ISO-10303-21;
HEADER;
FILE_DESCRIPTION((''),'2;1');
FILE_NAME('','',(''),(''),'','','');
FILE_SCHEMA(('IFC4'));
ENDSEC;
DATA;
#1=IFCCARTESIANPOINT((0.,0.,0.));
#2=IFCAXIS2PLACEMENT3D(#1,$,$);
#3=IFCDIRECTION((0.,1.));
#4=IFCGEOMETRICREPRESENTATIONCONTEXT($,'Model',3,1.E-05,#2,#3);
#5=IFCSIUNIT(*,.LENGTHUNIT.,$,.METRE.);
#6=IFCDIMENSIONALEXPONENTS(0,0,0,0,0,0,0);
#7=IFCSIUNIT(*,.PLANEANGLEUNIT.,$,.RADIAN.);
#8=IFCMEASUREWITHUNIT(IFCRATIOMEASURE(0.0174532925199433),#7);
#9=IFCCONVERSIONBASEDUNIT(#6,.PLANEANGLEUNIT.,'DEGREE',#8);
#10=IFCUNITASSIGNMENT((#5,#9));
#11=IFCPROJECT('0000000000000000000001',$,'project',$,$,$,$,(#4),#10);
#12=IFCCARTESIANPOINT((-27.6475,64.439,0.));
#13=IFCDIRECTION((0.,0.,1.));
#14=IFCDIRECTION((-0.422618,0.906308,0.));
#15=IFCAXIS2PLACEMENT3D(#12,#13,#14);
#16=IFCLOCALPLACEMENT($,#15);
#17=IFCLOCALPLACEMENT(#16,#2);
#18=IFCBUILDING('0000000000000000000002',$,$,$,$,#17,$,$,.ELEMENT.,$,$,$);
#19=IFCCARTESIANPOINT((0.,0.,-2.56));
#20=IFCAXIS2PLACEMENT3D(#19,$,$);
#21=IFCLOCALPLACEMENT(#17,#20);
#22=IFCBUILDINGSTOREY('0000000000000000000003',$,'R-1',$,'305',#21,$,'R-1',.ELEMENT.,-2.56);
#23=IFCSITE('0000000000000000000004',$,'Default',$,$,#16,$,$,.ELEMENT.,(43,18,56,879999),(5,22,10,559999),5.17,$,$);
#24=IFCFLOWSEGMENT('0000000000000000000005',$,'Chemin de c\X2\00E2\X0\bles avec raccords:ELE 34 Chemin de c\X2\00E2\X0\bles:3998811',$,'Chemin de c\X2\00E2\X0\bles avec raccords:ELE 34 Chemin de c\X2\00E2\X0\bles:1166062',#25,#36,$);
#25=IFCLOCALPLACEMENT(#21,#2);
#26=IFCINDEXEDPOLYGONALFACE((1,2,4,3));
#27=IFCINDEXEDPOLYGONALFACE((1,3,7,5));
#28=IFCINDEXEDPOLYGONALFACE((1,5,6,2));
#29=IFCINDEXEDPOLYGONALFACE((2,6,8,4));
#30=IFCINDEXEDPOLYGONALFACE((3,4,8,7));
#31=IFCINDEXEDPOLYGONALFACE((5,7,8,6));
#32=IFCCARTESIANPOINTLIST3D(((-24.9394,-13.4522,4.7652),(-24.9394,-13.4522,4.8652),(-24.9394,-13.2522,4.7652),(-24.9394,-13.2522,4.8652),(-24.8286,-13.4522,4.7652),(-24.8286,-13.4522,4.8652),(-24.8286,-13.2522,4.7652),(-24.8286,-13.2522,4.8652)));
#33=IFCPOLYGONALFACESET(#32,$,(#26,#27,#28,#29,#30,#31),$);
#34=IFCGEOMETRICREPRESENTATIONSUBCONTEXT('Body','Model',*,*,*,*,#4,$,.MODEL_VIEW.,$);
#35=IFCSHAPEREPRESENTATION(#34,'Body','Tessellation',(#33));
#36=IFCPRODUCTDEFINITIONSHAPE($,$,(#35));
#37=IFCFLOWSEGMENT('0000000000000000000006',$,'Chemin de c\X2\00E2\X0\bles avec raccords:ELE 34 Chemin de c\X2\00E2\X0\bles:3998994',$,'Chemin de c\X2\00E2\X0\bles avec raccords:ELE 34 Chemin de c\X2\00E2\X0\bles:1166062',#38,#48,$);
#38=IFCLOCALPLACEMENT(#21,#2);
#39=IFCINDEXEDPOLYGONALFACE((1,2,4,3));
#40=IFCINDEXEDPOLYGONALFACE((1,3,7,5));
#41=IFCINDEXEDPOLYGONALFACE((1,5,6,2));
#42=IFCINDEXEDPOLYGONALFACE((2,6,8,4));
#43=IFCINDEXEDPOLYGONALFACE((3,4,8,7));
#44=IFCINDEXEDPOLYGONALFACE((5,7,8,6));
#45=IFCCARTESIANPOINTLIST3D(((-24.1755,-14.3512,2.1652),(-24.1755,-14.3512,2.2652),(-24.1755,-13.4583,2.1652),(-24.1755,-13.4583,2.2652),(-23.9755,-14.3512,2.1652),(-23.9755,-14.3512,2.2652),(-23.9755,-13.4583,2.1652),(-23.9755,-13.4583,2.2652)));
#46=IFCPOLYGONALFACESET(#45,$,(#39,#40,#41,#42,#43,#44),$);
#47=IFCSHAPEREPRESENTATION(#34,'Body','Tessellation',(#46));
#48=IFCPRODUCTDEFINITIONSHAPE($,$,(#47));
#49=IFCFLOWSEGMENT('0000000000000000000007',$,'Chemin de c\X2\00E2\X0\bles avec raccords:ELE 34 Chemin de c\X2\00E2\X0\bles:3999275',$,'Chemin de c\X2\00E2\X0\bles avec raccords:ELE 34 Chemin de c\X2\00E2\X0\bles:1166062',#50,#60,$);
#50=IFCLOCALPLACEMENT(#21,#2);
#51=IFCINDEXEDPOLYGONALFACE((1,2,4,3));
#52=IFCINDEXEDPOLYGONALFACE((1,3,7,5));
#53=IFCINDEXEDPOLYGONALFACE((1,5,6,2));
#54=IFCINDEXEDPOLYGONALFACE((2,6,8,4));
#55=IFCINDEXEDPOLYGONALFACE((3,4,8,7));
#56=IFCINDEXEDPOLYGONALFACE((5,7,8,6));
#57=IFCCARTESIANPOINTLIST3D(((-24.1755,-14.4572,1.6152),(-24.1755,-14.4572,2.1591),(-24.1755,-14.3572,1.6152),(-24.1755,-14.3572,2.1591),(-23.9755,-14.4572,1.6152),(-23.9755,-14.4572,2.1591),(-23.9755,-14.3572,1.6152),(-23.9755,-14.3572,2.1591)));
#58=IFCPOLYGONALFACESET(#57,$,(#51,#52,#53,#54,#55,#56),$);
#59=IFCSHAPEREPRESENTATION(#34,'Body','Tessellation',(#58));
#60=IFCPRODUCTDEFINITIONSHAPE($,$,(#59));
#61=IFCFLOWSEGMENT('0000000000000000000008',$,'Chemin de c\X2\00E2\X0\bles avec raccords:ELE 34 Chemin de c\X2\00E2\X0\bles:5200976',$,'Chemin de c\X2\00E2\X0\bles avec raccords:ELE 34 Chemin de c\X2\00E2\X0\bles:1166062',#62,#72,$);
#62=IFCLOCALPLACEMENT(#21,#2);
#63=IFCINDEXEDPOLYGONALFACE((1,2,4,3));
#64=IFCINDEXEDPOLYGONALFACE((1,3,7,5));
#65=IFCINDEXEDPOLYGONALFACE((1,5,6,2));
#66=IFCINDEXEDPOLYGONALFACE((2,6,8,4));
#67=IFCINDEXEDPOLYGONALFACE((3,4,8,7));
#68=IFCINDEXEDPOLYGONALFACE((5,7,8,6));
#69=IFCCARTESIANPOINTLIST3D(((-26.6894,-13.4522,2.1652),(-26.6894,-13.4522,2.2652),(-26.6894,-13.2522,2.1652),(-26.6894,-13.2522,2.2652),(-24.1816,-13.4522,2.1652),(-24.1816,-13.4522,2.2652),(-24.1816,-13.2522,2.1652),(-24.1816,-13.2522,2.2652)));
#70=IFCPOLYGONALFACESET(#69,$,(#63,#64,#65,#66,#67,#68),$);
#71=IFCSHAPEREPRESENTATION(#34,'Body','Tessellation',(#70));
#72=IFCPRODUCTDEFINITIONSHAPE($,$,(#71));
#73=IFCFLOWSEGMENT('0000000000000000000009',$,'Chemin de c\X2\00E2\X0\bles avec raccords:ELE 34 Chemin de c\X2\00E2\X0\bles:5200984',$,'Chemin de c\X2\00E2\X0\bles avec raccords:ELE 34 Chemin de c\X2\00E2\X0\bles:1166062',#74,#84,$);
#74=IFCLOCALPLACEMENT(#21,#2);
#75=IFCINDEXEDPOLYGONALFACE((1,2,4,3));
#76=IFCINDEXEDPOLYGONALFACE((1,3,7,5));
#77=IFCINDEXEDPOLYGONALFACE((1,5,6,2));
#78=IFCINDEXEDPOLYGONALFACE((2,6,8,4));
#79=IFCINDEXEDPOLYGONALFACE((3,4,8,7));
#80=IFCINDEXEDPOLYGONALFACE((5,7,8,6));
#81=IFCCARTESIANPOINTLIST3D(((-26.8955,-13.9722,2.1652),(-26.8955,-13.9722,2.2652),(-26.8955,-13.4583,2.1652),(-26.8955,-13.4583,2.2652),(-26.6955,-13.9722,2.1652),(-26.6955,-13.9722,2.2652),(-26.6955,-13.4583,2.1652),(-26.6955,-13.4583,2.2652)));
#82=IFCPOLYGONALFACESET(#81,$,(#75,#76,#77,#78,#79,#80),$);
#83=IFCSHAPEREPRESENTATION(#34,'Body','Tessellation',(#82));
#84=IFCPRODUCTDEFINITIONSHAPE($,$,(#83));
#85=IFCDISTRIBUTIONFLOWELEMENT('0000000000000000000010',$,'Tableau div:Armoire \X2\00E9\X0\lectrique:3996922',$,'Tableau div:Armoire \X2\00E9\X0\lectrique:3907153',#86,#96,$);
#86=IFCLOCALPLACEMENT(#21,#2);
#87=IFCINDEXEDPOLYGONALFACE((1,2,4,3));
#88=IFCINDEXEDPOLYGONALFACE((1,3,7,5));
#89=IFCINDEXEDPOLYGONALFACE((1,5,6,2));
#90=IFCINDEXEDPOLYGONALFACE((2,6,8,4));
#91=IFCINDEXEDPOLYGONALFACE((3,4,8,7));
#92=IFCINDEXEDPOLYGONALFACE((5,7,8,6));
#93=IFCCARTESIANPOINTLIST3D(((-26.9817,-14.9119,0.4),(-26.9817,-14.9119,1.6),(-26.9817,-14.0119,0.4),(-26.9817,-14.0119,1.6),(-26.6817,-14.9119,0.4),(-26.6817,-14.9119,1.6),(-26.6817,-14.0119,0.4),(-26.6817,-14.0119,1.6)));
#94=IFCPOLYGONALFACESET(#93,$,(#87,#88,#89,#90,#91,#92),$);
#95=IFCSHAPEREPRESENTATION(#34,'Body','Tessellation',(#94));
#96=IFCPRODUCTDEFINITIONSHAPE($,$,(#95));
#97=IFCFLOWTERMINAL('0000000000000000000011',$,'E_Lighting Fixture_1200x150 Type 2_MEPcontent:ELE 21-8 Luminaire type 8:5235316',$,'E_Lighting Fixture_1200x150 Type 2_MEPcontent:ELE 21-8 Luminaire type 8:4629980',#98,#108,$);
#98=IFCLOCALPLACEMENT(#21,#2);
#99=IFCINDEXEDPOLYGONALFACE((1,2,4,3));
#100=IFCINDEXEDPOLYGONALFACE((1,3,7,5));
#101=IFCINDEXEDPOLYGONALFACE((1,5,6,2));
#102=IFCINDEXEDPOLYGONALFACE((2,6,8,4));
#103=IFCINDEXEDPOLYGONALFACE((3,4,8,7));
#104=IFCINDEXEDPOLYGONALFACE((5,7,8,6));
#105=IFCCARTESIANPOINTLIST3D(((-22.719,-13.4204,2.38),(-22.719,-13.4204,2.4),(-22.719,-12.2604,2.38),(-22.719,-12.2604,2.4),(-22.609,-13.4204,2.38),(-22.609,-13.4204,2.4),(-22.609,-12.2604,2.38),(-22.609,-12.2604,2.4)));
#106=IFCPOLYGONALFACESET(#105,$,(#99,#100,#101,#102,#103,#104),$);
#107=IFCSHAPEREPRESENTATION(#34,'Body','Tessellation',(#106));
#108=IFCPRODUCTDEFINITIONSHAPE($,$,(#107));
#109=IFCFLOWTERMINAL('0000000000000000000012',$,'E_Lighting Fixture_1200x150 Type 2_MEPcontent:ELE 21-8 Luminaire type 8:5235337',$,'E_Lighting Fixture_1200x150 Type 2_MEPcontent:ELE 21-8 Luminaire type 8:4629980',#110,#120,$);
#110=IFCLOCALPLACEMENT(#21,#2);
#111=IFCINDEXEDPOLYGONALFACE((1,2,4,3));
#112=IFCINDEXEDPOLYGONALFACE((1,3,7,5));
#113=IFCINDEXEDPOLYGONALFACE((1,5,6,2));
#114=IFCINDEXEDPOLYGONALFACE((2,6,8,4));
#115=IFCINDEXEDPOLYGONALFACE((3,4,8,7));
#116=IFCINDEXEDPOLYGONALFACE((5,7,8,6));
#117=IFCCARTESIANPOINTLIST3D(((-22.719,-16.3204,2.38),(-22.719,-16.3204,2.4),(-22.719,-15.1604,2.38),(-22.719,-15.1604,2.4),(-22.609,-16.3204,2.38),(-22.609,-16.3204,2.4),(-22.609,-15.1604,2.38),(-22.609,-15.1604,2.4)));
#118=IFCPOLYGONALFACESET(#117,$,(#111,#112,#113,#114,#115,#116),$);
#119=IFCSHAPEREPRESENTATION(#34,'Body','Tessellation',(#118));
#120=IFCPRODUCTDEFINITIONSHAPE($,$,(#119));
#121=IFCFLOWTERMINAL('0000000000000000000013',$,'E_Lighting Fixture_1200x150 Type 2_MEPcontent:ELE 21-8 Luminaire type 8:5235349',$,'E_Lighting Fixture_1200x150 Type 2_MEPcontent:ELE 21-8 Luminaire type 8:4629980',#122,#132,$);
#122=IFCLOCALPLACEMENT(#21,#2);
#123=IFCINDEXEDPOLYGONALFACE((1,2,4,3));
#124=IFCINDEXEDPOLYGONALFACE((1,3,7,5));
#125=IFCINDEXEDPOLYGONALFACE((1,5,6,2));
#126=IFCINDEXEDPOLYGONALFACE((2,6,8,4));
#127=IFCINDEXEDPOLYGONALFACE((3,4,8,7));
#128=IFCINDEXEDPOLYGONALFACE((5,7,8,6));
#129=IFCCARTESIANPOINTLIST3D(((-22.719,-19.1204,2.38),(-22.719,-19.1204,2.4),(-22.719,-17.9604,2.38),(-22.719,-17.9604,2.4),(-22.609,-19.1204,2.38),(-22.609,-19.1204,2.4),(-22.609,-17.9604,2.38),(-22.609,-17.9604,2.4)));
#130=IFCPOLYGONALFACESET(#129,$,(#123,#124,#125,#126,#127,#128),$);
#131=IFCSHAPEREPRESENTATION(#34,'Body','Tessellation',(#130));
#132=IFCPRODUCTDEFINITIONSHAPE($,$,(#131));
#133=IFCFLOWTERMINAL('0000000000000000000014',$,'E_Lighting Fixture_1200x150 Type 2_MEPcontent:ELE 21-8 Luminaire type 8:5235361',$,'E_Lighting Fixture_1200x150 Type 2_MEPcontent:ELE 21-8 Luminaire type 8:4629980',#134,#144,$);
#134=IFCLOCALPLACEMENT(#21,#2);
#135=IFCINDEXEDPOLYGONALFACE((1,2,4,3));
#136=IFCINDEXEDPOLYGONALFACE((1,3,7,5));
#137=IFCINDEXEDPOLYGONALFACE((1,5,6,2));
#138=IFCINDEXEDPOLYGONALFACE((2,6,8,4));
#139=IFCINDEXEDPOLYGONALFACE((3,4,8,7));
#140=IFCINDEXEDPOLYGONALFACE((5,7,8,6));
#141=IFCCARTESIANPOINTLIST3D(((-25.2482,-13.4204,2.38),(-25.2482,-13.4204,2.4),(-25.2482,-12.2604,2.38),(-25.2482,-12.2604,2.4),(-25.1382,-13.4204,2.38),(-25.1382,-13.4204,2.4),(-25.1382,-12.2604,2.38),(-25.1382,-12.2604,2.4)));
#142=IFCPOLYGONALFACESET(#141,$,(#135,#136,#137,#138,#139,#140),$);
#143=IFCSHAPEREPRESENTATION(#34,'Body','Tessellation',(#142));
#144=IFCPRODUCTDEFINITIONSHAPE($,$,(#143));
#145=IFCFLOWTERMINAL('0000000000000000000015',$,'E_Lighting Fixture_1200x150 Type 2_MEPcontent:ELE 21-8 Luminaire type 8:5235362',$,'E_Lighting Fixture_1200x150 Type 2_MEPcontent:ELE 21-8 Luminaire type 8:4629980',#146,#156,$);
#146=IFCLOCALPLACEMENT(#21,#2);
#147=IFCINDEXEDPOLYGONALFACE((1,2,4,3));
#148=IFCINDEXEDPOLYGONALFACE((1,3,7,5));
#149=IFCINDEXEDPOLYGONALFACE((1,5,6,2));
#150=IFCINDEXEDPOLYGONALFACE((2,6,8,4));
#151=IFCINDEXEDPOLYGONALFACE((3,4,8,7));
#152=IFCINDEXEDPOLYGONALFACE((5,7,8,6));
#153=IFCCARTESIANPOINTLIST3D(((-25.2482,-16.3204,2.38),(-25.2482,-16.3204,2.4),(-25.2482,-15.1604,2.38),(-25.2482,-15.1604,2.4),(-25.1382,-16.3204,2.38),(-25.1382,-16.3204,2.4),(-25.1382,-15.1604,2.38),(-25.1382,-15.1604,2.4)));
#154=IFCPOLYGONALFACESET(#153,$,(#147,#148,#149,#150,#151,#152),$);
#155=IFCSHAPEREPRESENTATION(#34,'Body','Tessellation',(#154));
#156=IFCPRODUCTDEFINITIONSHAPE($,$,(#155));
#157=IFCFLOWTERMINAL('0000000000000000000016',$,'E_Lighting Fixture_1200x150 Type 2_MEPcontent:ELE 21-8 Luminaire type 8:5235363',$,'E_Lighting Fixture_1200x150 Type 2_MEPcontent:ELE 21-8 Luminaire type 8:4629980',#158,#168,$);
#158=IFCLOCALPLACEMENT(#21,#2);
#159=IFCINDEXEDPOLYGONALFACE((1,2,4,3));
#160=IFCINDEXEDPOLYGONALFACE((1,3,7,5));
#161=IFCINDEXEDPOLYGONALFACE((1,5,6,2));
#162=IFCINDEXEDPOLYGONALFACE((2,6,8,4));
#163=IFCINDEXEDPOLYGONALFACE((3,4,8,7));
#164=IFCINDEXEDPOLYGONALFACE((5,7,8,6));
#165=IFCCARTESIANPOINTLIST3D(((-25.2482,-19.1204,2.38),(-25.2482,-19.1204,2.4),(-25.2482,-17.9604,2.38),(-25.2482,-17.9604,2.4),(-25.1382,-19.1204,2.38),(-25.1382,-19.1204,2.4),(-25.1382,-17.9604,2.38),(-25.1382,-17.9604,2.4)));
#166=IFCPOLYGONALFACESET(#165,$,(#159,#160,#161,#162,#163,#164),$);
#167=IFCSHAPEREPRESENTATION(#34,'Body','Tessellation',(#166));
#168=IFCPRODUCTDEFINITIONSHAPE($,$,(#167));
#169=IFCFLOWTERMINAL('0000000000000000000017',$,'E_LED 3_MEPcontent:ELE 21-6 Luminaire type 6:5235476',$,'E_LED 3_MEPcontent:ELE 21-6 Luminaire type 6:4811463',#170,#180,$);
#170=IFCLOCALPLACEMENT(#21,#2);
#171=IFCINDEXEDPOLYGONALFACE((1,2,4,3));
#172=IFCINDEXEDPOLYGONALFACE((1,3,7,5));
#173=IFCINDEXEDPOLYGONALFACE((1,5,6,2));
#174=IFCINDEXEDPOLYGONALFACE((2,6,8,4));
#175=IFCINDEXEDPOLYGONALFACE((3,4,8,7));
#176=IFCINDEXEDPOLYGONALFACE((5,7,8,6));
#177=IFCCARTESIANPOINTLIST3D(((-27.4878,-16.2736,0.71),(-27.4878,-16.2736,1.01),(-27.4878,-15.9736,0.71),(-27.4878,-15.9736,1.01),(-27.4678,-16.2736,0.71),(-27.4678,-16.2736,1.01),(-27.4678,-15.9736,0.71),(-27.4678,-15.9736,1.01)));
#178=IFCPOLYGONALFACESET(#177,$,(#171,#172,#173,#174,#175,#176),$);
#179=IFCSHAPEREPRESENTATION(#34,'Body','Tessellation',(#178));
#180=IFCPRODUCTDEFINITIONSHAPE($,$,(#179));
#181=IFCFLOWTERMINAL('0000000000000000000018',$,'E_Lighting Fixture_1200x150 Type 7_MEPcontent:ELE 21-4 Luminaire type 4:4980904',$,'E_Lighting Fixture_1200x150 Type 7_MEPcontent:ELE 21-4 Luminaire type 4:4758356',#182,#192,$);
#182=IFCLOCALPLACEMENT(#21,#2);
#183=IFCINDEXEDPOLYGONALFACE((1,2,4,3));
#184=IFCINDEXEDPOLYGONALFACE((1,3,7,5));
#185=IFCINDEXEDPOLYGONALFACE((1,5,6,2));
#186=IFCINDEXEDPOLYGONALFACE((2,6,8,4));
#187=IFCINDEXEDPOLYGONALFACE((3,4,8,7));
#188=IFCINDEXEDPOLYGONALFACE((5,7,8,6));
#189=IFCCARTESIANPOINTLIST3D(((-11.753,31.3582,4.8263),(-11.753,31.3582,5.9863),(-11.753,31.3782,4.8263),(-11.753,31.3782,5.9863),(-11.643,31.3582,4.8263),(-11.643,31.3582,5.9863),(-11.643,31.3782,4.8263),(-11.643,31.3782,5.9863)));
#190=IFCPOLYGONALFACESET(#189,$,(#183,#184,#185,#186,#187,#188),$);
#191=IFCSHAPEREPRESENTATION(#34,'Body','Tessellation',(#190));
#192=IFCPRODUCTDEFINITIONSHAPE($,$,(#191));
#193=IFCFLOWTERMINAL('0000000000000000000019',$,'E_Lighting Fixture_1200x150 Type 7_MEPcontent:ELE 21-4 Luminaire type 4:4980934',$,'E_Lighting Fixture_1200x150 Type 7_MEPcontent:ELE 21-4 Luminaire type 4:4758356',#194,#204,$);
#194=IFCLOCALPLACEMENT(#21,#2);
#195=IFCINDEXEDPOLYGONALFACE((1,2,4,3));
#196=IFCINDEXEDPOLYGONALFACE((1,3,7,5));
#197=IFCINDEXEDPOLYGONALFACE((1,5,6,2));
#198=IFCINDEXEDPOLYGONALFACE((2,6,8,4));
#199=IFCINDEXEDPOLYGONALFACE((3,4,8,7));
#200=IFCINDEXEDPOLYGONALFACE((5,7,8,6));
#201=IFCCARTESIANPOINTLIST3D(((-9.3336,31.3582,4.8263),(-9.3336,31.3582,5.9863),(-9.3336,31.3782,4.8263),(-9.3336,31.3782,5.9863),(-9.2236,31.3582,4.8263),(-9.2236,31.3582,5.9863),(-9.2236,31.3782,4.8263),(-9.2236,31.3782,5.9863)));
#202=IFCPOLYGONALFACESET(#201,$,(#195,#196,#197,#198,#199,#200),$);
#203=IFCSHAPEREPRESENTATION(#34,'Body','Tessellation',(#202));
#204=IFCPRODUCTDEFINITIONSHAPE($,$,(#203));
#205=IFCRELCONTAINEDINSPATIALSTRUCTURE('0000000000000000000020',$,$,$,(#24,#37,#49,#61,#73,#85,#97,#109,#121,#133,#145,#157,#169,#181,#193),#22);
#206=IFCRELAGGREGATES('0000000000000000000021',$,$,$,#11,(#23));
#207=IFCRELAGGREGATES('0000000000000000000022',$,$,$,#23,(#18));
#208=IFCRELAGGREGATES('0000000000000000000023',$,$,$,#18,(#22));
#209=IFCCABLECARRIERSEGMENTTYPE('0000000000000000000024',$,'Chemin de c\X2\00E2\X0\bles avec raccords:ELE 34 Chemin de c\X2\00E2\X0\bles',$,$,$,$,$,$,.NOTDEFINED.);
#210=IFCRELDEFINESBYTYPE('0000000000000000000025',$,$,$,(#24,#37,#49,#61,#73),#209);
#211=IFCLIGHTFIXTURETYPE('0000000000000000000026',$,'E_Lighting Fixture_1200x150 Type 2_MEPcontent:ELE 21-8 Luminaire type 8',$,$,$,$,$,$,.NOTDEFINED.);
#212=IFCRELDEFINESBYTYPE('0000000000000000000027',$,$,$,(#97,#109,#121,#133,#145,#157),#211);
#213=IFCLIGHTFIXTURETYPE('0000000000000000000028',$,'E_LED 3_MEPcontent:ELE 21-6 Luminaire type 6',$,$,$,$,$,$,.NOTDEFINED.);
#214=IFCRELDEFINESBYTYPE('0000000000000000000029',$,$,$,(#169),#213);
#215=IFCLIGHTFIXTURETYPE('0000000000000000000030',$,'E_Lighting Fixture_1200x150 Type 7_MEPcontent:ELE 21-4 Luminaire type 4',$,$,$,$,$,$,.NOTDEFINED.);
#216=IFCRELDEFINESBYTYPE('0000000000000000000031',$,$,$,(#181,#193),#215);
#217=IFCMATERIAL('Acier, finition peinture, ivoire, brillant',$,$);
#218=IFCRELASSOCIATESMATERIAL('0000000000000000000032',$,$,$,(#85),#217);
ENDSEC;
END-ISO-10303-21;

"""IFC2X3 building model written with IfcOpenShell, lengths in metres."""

from ifc_helpers import new_model, entity, si_unit, converted_unit, direction, frame, frame_2d, origin, origin_2d_with_axis, place, context, subcontext, project, spatial, rectangle, extrude, source, transform, mapped, material, type_object, type_shapes, element, save


model = new_model("IFC2X3")

# Units and contexts
model_context = context("Model", 3, precision=1e-05, world=origin(), true_north=direction((0.0, 1.0)))
body_context = subcontext(model_context, "Body", "Model", "MODEL_VIEW")
ifc_project = project(units=[si_unit("LENGTHUNIT", "METRE"), converted_unit("PLANEANGLEUNIT", "DEGREE", entity("IfcRatioMeasure", 0.0174532925199433), si_unit("PLANEANGLEUNIT", "RADIAN"), dimensions=[0, 0, 0, 0, 0, 0, 0])], contexts=[model_context])

# Site, building, storey
site_placement = place(None, frame((-27.6475, 64.439, 0.0), z_axis=(0.0, 0.0, 1.0), x_axis=(-0.422618, 0.906308, 0.0)))
site = spatial("IfcSite", under=ifc_project, at=site_placement, Name="Default", CompositionType="ELEMENT", RefLatitude=(43, 18, 56, 879999), RefLongitude=(5, 22, 10, 559999), RefElevation=5.17)
building_placement = place(site_placement, origin())
building = spatial("IfcBuilding", under=site, at=building_placement, CompositionType="ELEMENT")
storey_placement = place(building_placement, frame((0.0, 0.0, -2.56)))
storey = spatial("IfcBuildingStorey", under=building, at=storey_placement, Name="R-1", ObjectType="305", LongName="R-1", CompositionType="ELEMENT", Elevation=-2.56)

# Flow segments
cable_carrier_segment_type = type_object("IfcCableCarrierSegmentType", Name="Chemin de câbles avec raccords:ELE 34 Chemin de câbles", PredefinedType="NOTDEFINED")
flow_segment_1_placement = place(storey_placement, origin())
element("IfcFlowSegment", 1, at=flow_segment_1_placement, inside=storey, type_object=cable_carrier_segment_type, Name="Chemin de câbles avec raccords:ELE 34 Chemin de câbles:3998811", ObjectType="Chemin de câbles avec raccords:ELE 34 Chemin de câbles:1166062", context=body_context, shape_type="SweptSolid", body=[
    extrude(rectangle(XDim=0.1109, YDim=0.2, at=frame_2d((0.0, 0.0), x_axis=(1.0, 0.0))), frame((-24.884, -13.3522, 4.7652)), (0.0, 0.0, 1.0), 0.1),
])
flow_segment_2_placement = place(storey_placement, origin())
element("IfcFlowSegment", 2, at=flow_segment_2_placement, inside=storey, type_object=cable_carrier_segment_type, Name="Chemin de câbles avec raccords:ELE 34 Chemin de câbles:3998994", ObjectType="Chemin de câbles avec raccords:ELE 34 Chemin de câbles:1166062", context=body_context, shape_type="SweptSolid", body=[
    extrude(rectangle(XDim=0.8928, YDim=0.2, at=frame_2d((0.0, 0.0), x_axis=(1.0, 0.0))), frame((-24.0755, -13.9047, 2.1652), z_axis=(0.0, -0.000001, 1.0), x_axis=(0.0, -1.0, -0.000001)), (0.0, 0.0, 1.0), 0.1),
])
flow_segment_3_placement = place(storey_placement, origin())
element("IfcFlowSegment", 3, at=flow_segment_3_placement, inside=storey, type_object=cable_carrier_segment_type, Name="Chemin de câbles avec raccords:ELE 34 Chemin de câbles:3999275", ObjectType="Chemin de câbles avec raccords:ELE 34 Chemin de câbles:1166062", context=body_context, shape_type="SweptSolid", body=[
    extrude(rectangle(XDim=0.1, YDim=0.2, at=origin_2d_with_axis()), frame((-24.0755, -14.4072, 1.6152), z_axis=(0.0, 0.0, 1.0), x_axis=(0.0, -1.0, 0.0)), (0.0, 0.0, 1.0), 0.5439),
])
flow_segment_4_placement = place(storey_placement, origin())
element("IfcFlowSegment", 4, at=flow_segment_4_placement, inside=storey, type_object=cable_carrier_segment_type, Name="Chemin de câbles avec raccords:ELE 34 Chemin de câbles:5200976", ObjectType="Chemin de câbles avec raccords:ELE 34 Chemin de câbles:1166062", context=body_context, shape_type="SweptSolid", body=[
    extrude(rectangle(XDim=2.5078, YDim=0.2, at=origin_2d_with_axis()), frame((-25.4355, -13.3522, 2.1652), z_axis=(0.0, 0.0, 1.0), x_axis=(-1.0, 0.0, 0.0)), (0.0, 0.0, 1.0), 0.1),
])
flow_segment_5_placement = place(storey_placement, origin())
element("IfcFlowSegment", 5, at=flow_segment_5_placement, inside=storey, type_object=cable_carrier_segment_type, Name="Chemin de câbles avec raccords:ELE 34 Chemin de câbles:5200984", ObjectType="Chemin de câbles avec raccords:ELE 34 Chemin de câbles:1166062", context=body_context, shape_type="SweptSolid", body=[
    extrude(rectangle(XDim=0.5139, YDim=0.2, at=frame_2d((0.0, 0.0), x_axis=(1.0, 0.0))), frame((-26.7955, -13.7153, 2.1652), z_axis=(0.0, 0.0, 1.0), x_axis=(0.0, -1.0, 0.0)), (0.0, 0.0, 1.0), 0.1),
])

# Distribution flow element
ifc_material = material(Name="Acier, finition peinture, ivoire, brillant")
shared_shape_1 = source(origin(), body_context, "Body", "SweptSolid", [
    extrude(rectangle(XDim=0.9, YDim=0.3, at=origin_2d_with_axis()), frame((0.0, -0.45, 0.0), z_axis=(0.0, 0.0, 1.0), x_axis=(0.0, 1.0, 0.0)), (0.0, 0.0, 1.0), 1.2),
])
distribution_flow_element_placement = place(storey_placement, frame((-26.8317, -14.0119, 0.4)))
element("IfcDistributionFlowElement", 6, at=distribution_flow_element_placement, inside=storey, material=ifc_material, Name="Tableau div:Armoire électrique:3996922", ObjectType="Tableau div:Armoire électrique:3907153", context=body_context, shape_type="MappedRepresentation", body=[
    mapped(shared_shape_1, transform((0.0, 0.0, 0.0), scale=1.0)),
])

# Flow terminals
light_fixture_type_1 = type_object("IfcLightFixtureType", Name="E_Lighting Fixture_1200x150 Type 2_MEPcontent:ELE 21-8 Luminaire type 8", PredefinedType="NOTDEFINED")
shared_shape_2 = source(origin(), body_context, "Body", "SweptSolid", [
    extrude(rectangle(XDim=0.11, YDim=1.16, at=origin_2d_with_axis()), frame((0.0, 0.0, 0.0), z_axis=(0.0, 0.0, 1.0), x_axis=(0.0, -1.0, 0.0)), (0.0, 0.0, 1.0), 0.02),
])
type_shapes(light_fixture_type_1, [shared_shape_2])
for number, where, z_axis, x_axis, name in (
    (7, (-22.664, -12.8404, 2.38), (0.0, 0.0, 1.0), (0.0, -1.0, 0.0), "E_Lighting Fixture_1200x150 Type 2_MEPcontent:ELE 21-8 Luminaire type 8:5235316"),
    (8, (-22.664, -15.7404, 2.38), (0.0, 0.0, 1.0), (0.0, -1.0, 0.0), "E_Lighting Fixture_1200x150 Type 2_MEPcontent:ELE 21-8 Luminaire type 8:5235337"),
    (9, (-22.664, -18.5404, 2.38), (0.0, 0.0, 1.0), (0.0, -1.0, 0.0), "E_Lighting Fixture_1200x150 Type 2_MEPcontent:ELE 21-8 Luminaire type 8:5235349"),
    (10, (-25.1932, -12.8404, 2.38), (0.0, 0.0, 1.0), (0.0, -1.0, 0.0), "E_Lighting Fixture_1200x150 Type 2_MEPcontent:ELE 21-8 Luminaire type 8:5235361"),
    (11, (-25.1932, -15.7404, 2.38), (0.0, 0.0, 1.0), (0.0, -1.0, 0.0), "E_Lighting Fixture_1200x150 Type 2_MEPcontent:ELE 21-8 Luminaire type 8:5235362"),
    (12, (-25.1932, -18.5404, 2.38), (0.0, 0.0, 1.0), (0.0, -1.0, 0.0), "E_Lighting Fixture_1200x150 Type 2_MEPcontent:ELE 21-8 Luminaire type 8:5235363"),
):
    element("IfcFlowTerminal", number, at=place(storey_placement, frame(where, z_axis=z_axis, x_axis=x_axis)), inside=storey, type_object=light_fixture_type_1, Name=name, ObjectType="E_Lighting Fixture_1200x150 Type 2_MEPcontent:ELE 21-8 Luminaire type 8:4629980", context=body_context, shape_type="MappedRepresentation", body=[
        mapped(shared_shape_2, transform((0.0, 0.0, 0.0), scale=1.0)),
    ])
light_fixture_type_2 = type_object("IfcLightFixtureType", Name="E_LED 3_MEPcontent:ELE 21-6 Luminaire type 6", PredefinedType="NOTDEFINED")
shared_shape_3 = source(origin(), body_context, "Body", "SweptSolid", [
    extrude(rectangle(XDim=0.02, YDim=0.3, at=origin_2d_with_axis()), frame((0.0, 0.01, -0.15), z_axis=(0.0, 0.0, 1.0), x_axis=(0.0, -1.0, 0.0)), (0.0, 0.0, 1.0), 0.3),
])
type_shapes(light_fixture_type_2, [shared_shape_3])
flow_terminal_placement = place(storey_placement, frame((-27.4878, -16.1236, 0.86), z_axis=(0.0, 0.0, 1.0), x_axis=(0.0, -1.0, 0.0)))
element("IfcFlowTerminal", 13, at=flow_terminal_placement, inside=storey, type_object=light_fixture_type_2, Name="E_LED 3_MEPcontent:ELE 21-6 Luminaire type 6:5235476", ObjectType="E_LED 3_MEPcontent:ELE 21-6 Luminaire type 6:4811463", context=body_context, shape_type="MappedRepresentation", body=[
    mapped(shared_shape_3, transform((0.0, 0.0, 0.0), scale=1.0)),
])
light_fixture_type_3 = type_object("IfcLightFixtureType", Name="E_Lighting Fixture_1200x150 Type 7_MEPcontent:ELE 21-4 Luminaire type 4", PredefinedType="NOTDEFINED")
shared_shape_4 = source(origin(), body_context, "Body", "SweptSolid", [
    extrude(rectangle(XDim=0.02, YDim=0.11, at=frame_2d((0.0, 0.0), x_axis=(1.0, 0.0))), frame((0.01, 0.0, -0.58), z_axis=(0.0, 0.0, 1.0), x_axis=(-1.0, 0.0, 0.0)), (0.0, 0.0, 1.0), 1.16),
])
type_shapes(light_fixture_type_3, [shared_shape_4])
for number, where, z_axis, x_axis, name in (
    (14, (-11.698, 31.3782, 5.4063), (0.0, 0.0, 1.0), (0.0, -1.0, 0.0), "E_Lighting Fixture_1200x150 Type 7_MEPcontent:ELE 21-4 Luminaire type 4:4980904"),
    (15, (-9.2786, 31.3782, 5.4063), (0.0, 0.0, 1.0), (0.0, -1.0, 0.0), "E_Lighting Fixture_1200x150 Type 7_MEPcontent:ELE 21-4 Luminaire type 4:4980934"),
):
    element("IfcFlowTerminal", number, at=place(storey_placement, frame(where, z_axis=z_axis, x_axis=x_axis)), inside=storey, type_object=light_fixture_type_3, Name=name, ObjectType="E_Lighting Fixture_1200x150 Type 7_MEPcontent:ELE 21-4 Luminaire type 4:4758356", context=body_context, shape_type="MappedRepresentation", body=[
        mapped(shared_shape_4, transform((0.0, 0.0, 0.0), scale=1.0)),
    ])

save(model, "model.ifc")
